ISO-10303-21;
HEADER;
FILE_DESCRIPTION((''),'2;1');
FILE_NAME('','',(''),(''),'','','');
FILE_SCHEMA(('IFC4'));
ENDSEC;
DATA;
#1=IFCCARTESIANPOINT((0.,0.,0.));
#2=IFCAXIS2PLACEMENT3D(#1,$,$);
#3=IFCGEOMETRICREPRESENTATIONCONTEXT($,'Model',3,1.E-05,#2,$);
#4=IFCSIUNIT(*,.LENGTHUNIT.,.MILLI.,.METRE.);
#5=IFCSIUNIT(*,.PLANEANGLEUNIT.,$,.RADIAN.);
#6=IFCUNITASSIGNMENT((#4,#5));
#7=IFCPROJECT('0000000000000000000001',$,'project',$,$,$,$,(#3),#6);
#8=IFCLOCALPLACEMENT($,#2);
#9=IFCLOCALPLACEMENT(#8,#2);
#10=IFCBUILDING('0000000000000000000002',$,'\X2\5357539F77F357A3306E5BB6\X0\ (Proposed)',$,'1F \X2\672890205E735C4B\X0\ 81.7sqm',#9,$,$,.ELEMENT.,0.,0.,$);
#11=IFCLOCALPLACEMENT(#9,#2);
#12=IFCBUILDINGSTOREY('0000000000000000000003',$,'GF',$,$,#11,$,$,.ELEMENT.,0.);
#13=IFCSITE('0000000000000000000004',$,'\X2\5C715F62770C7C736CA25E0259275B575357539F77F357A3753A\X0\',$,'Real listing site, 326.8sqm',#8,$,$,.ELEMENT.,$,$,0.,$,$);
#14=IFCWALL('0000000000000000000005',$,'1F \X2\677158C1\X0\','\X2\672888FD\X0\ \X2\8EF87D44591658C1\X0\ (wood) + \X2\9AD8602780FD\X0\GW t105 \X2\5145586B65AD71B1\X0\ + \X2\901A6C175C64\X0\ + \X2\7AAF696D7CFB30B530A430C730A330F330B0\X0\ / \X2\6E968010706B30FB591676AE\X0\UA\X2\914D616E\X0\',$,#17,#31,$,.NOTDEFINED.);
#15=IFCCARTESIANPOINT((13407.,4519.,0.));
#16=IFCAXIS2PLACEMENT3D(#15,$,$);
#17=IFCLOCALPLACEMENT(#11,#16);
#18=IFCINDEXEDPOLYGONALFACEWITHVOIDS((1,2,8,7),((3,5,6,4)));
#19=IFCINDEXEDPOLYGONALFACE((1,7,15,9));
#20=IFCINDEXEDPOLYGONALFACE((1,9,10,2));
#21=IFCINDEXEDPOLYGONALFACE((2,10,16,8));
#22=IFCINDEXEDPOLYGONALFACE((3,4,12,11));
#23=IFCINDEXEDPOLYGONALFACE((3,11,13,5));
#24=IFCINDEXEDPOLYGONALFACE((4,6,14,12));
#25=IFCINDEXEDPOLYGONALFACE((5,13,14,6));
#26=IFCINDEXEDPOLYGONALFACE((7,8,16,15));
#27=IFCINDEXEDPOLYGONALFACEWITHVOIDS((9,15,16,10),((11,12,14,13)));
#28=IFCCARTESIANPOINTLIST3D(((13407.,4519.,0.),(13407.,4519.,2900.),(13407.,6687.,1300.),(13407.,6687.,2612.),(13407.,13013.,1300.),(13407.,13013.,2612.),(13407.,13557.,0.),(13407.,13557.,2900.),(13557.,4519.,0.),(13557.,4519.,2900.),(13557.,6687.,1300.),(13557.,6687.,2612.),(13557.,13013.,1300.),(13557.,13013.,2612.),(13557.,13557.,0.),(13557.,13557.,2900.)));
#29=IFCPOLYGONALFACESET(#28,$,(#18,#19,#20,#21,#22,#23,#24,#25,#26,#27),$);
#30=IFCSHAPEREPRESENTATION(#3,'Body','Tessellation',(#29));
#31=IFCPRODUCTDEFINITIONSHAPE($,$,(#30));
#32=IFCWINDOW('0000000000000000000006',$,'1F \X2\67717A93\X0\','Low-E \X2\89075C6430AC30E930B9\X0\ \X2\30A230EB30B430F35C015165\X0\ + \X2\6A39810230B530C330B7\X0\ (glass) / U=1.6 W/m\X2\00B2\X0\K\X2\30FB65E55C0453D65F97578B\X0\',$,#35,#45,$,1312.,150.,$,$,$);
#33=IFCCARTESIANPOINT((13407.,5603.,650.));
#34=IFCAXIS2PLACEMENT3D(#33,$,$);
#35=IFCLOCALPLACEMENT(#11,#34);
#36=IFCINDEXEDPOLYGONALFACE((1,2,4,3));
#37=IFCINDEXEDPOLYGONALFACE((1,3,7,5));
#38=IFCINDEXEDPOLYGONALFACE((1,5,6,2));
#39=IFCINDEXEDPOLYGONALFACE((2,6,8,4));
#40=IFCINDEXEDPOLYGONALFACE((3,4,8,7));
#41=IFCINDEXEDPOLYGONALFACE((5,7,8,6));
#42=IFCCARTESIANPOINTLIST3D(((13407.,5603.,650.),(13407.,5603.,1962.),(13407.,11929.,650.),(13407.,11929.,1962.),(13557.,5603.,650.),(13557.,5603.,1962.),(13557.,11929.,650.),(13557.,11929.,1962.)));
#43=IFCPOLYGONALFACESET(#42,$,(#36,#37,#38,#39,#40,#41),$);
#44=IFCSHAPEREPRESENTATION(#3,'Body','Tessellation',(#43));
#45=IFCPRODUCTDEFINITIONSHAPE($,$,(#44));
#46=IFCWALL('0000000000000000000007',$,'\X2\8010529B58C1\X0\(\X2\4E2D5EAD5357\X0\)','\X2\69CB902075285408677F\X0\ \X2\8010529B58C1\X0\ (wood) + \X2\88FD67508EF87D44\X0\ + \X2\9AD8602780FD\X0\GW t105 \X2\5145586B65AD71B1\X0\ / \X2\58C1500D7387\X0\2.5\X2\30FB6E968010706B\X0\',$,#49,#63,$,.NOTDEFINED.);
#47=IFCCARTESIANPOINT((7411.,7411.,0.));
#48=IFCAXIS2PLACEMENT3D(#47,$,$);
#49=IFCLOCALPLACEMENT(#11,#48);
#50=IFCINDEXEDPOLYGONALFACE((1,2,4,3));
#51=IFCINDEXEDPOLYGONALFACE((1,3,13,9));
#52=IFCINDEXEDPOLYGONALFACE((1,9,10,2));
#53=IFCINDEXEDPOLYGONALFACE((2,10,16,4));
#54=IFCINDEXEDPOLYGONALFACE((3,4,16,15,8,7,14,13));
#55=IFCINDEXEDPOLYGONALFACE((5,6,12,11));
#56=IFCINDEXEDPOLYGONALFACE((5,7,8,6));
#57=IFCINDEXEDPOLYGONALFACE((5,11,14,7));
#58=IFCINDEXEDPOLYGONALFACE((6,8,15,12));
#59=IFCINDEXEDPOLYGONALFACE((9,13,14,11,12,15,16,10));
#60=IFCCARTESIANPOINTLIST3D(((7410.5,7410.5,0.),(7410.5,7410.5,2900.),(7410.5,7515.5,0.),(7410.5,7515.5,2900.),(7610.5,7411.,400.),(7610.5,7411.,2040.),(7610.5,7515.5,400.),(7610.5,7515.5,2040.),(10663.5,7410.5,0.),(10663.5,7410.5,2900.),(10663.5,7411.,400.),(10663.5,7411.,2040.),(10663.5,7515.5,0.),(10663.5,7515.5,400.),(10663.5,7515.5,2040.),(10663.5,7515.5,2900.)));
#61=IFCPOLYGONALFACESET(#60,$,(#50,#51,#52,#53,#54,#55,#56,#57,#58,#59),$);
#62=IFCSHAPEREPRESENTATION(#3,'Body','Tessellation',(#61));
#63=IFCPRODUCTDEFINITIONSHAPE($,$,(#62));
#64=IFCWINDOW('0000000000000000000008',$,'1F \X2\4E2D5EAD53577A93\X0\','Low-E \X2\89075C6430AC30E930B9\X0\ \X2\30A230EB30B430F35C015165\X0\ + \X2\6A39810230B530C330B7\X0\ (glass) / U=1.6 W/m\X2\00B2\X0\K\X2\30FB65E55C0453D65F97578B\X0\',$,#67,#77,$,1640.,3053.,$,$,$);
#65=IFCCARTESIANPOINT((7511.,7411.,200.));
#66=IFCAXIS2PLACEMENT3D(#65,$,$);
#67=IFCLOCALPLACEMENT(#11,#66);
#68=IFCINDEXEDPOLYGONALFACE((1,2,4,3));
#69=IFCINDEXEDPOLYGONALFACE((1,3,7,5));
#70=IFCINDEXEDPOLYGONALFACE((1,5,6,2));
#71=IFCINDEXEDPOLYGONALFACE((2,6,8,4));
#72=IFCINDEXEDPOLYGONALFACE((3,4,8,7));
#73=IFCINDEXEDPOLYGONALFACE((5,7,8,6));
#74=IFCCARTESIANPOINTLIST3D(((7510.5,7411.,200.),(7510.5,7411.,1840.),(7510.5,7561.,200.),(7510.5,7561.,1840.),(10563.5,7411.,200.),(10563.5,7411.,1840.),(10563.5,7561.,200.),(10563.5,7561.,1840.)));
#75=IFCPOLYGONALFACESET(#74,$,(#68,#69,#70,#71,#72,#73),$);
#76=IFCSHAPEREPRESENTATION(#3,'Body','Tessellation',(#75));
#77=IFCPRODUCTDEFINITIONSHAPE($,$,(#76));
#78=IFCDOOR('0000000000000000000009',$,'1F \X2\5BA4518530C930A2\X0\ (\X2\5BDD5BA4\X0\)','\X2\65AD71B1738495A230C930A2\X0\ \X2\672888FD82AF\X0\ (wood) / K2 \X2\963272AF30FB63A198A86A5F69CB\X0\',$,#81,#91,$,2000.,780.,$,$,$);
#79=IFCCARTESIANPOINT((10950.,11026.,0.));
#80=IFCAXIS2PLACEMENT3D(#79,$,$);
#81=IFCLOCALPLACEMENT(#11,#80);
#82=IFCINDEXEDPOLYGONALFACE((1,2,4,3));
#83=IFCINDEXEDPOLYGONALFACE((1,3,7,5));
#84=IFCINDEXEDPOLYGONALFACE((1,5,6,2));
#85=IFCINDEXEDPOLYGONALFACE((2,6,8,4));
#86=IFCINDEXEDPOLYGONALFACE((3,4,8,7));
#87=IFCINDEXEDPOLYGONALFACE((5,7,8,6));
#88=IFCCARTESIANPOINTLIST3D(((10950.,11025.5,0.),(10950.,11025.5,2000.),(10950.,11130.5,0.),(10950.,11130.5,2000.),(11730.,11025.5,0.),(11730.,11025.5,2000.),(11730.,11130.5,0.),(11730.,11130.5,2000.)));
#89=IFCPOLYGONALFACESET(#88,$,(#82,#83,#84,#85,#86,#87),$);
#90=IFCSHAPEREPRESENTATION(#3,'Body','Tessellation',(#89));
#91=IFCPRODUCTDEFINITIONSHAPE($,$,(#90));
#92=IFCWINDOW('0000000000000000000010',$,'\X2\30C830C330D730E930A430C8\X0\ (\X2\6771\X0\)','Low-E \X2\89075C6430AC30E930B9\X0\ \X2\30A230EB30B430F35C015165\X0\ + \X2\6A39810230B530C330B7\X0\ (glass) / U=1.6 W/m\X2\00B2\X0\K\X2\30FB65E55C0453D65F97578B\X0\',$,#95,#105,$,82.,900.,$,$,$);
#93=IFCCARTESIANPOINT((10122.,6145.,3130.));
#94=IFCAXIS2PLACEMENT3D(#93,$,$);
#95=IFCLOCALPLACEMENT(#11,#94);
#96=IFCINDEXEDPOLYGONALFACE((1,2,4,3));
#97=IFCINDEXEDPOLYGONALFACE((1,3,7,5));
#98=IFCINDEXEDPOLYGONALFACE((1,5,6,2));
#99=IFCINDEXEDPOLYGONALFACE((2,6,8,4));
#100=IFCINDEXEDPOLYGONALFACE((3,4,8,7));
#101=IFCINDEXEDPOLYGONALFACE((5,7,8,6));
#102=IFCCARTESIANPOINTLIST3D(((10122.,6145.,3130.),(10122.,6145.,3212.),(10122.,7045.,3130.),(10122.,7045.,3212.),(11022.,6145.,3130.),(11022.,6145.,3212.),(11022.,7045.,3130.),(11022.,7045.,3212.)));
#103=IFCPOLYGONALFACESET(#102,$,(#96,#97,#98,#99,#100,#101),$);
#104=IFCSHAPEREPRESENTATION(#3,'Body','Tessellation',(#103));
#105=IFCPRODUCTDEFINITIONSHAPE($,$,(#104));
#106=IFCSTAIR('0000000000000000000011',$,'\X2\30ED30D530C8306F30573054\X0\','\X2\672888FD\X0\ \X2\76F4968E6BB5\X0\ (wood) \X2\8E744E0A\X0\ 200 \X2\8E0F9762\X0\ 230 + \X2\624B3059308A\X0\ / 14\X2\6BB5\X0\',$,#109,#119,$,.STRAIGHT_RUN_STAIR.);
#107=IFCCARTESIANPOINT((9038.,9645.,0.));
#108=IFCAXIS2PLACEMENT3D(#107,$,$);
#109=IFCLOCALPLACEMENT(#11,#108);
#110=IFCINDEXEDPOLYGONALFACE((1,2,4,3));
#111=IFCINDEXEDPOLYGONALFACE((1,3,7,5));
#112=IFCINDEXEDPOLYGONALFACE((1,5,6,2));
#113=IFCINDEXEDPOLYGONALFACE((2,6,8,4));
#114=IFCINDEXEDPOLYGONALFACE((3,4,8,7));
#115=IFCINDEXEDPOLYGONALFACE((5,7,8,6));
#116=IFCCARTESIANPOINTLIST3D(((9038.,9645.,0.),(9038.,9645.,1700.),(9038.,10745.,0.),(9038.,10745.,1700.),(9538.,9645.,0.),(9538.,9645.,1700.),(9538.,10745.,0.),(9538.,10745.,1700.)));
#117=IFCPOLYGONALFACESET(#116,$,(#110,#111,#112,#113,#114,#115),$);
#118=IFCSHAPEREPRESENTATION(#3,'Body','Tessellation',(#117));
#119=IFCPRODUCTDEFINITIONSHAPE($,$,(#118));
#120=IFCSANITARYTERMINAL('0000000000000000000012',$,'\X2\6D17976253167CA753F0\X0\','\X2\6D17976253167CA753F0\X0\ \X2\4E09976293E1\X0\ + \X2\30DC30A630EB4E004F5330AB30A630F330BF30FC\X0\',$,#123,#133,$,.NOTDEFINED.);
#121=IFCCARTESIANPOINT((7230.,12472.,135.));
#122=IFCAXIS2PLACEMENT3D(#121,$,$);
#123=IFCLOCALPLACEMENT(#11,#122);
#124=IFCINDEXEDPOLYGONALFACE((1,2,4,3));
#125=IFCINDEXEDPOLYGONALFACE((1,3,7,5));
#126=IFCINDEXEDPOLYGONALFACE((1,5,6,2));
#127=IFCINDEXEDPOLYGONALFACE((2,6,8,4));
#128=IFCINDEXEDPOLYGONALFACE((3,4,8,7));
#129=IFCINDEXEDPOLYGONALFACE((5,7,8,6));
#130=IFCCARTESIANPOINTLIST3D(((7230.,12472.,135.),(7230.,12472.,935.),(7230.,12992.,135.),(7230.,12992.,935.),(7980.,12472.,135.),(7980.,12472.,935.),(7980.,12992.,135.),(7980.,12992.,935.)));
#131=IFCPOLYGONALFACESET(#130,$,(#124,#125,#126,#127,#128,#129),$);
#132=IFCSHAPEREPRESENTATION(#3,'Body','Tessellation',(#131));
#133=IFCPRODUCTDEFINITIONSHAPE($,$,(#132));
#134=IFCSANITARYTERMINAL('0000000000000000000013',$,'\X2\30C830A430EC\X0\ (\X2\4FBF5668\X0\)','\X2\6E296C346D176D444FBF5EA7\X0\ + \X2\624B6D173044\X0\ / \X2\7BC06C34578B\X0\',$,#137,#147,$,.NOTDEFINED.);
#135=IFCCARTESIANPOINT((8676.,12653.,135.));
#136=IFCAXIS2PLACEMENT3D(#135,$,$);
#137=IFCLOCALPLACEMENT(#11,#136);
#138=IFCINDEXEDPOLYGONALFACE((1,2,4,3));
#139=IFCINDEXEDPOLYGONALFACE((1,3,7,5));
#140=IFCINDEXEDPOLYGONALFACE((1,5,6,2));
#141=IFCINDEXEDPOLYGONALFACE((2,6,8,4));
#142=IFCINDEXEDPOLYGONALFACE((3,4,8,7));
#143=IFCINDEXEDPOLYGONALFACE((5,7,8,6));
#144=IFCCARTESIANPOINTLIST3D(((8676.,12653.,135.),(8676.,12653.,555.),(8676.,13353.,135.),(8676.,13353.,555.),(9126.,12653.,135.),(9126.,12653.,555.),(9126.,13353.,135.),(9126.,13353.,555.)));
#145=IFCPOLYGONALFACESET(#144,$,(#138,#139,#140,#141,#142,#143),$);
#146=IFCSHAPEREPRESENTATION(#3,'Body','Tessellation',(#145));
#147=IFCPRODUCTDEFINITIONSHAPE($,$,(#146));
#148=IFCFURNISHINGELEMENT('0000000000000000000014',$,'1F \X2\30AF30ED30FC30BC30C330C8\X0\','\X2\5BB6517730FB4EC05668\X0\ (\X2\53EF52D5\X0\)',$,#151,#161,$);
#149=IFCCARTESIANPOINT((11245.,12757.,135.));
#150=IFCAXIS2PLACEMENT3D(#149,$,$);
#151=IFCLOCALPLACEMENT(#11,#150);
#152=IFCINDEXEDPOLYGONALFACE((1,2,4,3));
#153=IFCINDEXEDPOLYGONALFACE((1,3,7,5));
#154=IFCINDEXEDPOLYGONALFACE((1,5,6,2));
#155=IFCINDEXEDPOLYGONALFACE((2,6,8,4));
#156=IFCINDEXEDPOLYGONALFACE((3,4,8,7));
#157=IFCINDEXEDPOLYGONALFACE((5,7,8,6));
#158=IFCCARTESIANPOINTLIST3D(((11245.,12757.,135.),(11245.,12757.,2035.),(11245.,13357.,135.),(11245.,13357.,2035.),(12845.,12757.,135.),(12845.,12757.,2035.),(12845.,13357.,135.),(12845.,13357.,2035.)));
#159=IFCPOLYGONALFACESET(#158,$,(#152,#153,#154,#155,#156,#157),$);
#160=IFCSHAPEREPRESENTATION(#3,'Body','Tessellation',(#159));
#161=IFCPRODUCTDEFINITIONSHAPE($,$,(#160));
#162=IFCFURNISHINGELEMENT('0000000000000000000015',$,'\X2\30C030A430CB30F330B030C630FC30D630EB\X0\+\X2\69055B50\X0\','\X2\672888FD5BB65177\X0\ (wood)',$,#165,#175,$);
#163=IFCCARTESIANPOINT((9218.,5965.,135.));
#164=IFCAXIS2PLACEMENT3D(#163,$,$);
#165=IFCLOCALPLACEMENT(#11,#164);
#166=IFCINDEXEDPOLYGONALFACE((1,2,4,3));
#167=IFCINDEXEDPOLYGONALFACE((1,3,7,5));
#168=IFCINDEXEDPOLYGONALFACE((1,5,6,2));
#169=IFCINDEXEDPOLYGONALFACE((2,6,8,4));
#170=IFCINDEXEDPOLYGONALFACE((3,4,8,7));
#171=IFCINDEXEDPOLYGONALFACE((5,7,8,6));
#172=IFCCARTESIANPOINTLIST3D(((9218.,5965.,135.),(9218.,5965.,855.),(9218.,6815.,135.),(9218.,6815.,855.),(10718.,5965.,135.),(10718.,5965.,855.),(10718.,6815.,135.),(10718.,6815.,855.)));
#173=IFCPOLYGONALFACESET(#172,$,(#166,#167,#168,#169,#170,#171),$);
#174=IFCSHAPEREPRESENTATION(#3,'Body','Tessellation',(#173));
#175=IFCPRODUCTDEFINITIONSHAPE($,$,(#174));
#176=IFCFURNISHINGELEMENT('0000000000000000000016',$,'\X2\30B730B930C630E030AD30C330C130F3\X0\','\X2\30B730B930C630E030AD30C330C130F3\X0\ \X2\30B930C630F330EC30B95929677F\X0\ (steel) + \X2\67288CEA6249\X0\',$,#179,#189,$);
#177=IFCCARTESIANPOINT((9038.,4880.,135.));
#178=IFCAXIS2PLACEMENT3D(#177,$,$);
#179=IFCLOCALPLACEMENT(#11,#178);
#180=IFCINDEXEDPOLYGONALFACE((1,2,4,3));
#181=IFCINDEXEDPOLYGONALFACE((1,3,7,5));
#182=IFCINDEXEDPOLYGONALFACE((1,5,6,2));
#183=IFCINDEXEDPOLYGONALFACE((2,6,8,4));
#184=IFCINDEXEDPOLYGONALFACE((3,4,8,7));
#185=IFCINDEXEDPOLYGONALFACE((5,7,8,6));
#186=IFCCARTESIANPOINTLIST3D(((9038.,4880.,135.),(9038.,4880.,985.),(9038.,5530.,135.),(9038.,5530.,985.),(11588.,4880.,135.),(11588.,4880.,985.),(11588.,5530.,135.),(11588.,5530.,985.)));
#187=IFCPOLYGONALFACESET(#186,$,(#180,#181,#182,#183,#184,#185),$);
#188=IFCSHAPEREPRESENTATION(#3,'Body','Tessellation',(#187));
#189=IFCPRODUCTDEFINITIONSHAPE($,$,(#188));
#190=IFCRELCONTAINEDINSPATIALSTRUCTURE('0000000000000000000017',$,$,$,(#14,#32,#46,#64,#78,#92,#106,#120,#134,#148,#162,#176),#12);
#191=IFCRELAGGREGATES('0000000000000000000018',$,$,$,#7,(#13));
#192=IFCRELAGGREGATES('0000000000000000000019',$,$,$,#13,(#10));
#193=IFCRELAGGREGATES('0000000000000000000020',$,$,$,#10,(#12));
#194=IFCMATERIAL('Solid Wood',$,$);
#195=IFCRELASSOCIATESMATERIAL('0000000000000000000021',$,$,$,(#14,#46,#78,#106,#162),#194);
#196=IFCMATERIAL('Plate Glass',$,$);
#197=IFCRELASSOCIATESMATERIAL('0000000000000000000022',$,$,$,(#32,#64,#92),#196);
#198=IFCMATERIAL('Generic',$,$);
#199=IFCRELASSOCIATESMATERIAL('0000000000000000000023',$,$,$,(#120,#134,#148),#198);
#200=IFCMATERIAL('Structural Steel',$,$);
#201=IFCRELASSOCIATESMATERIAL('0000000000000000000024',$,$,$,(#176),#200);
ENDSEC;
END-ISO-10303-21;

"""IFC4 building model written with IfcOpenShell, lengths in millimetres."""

from ifc_helpers import new_model, si_unit, frame, frame_2d, origin, place, context, project, spatial, rectangle, extrude, material, element, fill, save


model = new_model("IFC4")

# Units and contexts
model_context = context("Model", 3, precision=1e-05, world=origin())
ifc_project = project(units=[si_unit("LENGTHUNIT", "METRE", prefix="MILLI"), si_unit("PLANEANGLEUNIT", "RADIAN")], contexts=[model_context])

# Site, building, storey
site_placement = place(None, origin())
site = spatial("IfcSite", under=ifc_project, at=site_placement, Name="山形県米沢市大字南原石垣町", ObjectType="Real listing site, 326.8sqm", CompositionType="ELEMENT", RefElevation=0.0)
building_placement = place(site_placement, origin())
building = spatial("IfcBuilding", under=site, at=building_placement, Name="南原石垣の家 (Proposed)", ObjectType="1F 木造平屋 81.7sqm", CompositionType="ELEMENT", ElevationOfRefHeight=0.0, ElevationOfTerrain=0.0)
storey_placement = place(building_placement, origin())
storey = spatial("IfcBuildingStorey", under=building, at=storey_placement, Name="GF", CompositionType="ELEMENT", Elevation=0.0)

# Shared definitions
ifc_material_1 = material(Name="Solid Wood")

# Walls, openings, windows
wall_1_placement = place(storey_placement, frame((13407.0, 4519.0, 0.0)))
wall_1 = element("IfcWall", 1, at=wall_1_placement, inside=storey, material=ifc_material_1, Name="1F 東壁", Description="木製 軸組外壁 (wood) + 高性能GW t105 充填断熱 + 通気層 + 窯業系サイディング / 準耐火・外皮UA配慮", PredefinedType="NOTDEFINED", context=model_context, shape_type="SweptSolid", body=[
    extrude(rectangle(XDim=150.0, YDim=9038.0, at=frame_2d((75.0, 4519.0))), frame((13407.0, 4519.0, 0.0)), (0.0, 0.0, 1.0), 2900.0),
])
opening_1_placement = place(storey_placement, frame((13407.0, 5603.0, 650.0)))
opening_1 = element("IfcOpeningElement", 2, at=opening_1_placement, cuts=wall_1, PredefinedType="NOTDEFINED", context=model_context, shape_type="SweptSolid", body=[
    extrude(rectangle(XDim=150.0, YDim=6326.0, at=frame_2d((75.0, 3163.0))), frame((13407.0, 5603.0, 650.0)), (0.0, 0.0, 1.0), 1312.0),
])
ifc_material_2 = material(Name="Plate Glass")
window_1_placement = place(storey_placement, frame((13407.0, 5603.0, 650.0)))
window_1 = element("IfcWindow", 3, at=window_1_placement, inside=storey, material=ifc_material_2, Name="1F 東窓", Description="Low-E 複層ガラス アルゴン封入 + 樹脂サッシ (glass) / U=1.6 W/m²K・日射取得型", OverallHeight=1312.0, OverallWidth=150.0, context=model_context, shape_type="SweptSolid", body=[
    extrude(rectangle(XDim=150.0, YDim=6326.0, at=frame_2d((75.0, 3163.0))), frame((13407.0, 5603.0, 650.0)), (0.0, 0.0, 1.0), 1312.0),
])
fill(opening_1, window_1)
wall_2_placement = place(storey_placement, frame((7411.0, 7411.0, 0.0)))
wall_2 = element("IfcWall", 4, at=wall_2_placement, inside=storey, material=ifc_material_1, Name="耐力壁(中庭南)", Description="構造用合板 耐力壁 (wood) + 製材軸組 + 高性能GW t105 充填断熱 / 壁倍率2.5・準耐火", PredefinedType="NOTDEFINED", context=model_context, shape_type="SweptSolid", body=[
    extrude(rectangle(XDim=3253.0, YDim=105.0, at=frame_2d((1626.0, 52.0))), frame((7411.0, 7411.0, 0.0)), (0.0, 0.0, 1.0), 2900.0),
])
opening_2_placement = place(storey_placement, frame((7511.0, 7411.0, 200.0)))
opening_2 = element("IfcOpeningElement", 5, at=opening_2_placement, cuts=wall_2, PredefinedType="NOTDEFINED", context=model_context, shape_type="SweptSolid", body=[
    extrude(rectangle(XDim=3053.0, YDim=150.0, at=frame_2d((1526.0, 75.0))), frame((7511.0, 7411.0, 200.0)), (0.0, 0.0, 1.0), 1640.0),
])
window_2_placement = place(storey_placement, frame((7511.0, 7411.0, 200.0)))
window_2 = element("IfcWindow", 6, at=window_2_placement, inside=storey, material=ifc_material_2, Name="1F 中庭南窓", Description="Low-E 複層ガラス アルゴン封入 + 樹脂サッシ (glass) / U=1.6 W/m²K・日射取得型", OverallHeight=1640.0, OverallWidth=3053.0, context=model_context, shape_type="SweptSolid", body=[
    extrude(rectangle(XDim=3053.0, YDim=150.0, at=frame_2d((1526.0, 75.0))), frame((7511.0, 7411.0, 200.0)), (0.0, 0.0, 1.0), 1640.0),
])
fill(opening_2, window_2)

# Door
door_placement = place(storey_placement, frame((10950.0, 11026.0, 0.0)))
element("IfcDoor", 7, at=door_placement, inside=storey, material=ifc_material_1, Name="1F 室内ドア (寝室)", Description="断熱玄関ドア 木製芯 (wood) / K2 防犯・採風機構", OverallHeight=2000.0, OverallWidth=780.0, context=model_context, shape_type="SweptSolid", body=[
    extrude(rectangle(XDim=780.0, YDim=105.0, at=frame_2d((390.0, 52.0))), frame((10950.0, 11026.0, 0.0)), (0.0, 0.0, 1.0), 2000.0),
])

# Window
window_3_placement = place(storey_placement, frame((10122.0, 6145.0, 3130.0)))
element("IfcWindow", 8, at=window_3_placement, inside=storey, material=ifc_material_2, Name="トップライト (東)", Description="Low-E 複層ガラス アルゴン封入 + 樹脂サッシ (glass) / U=1.6 W/m²K・日射取得型", OverallHeight=82.0, OverallWidth=900.0, context=model_context, shape_type="SweptSolid", body=[
    extrude(rectangle(XDim=900.0, YDim=900.0, at=frame_2d((450.0, 450.0))), frame((10122.0, 6145.0, 3130.0)), (0.0, 0.0, 1.0), 82.0),
])

# Stair
stair_placement = place(storey_placement, frame((9038.0, 9645.0, 0.0)))
element("IfcStair", 9, at=stair_placement, inside=storey, material=ifc_material_1, Name="ロフトはしご", Description="木製 直階段 (wood) 蹴上 200 踏面 230 + 手すり / 14段", PredefinedType="STRAIGHT_RUN_STAIR", context=model_context, shape_type="SweptSolid", body=[
    extrude(rectangle(XDim=500.0, YDim=1100.0, at=frame_2d((250.0, 550.0))), frame((9038.0, 9645.0, 0.0)), (0.0, 0.0, 1.0), 1700.0),
])

# Shared definitions
ifc_material_3 = material(Name="Structural Steel")

# Shared definitions
ifc_material_4 = material(Name="Generic")

# Sanitary terminals
sanitary_terminal_1_placement = place(storey_placement, frame((7230.0, 12472.0, 135.0)))
element("IfcSanitaryTerminal", 10, at=sanitary_terminal_1_placement, inside=storey, material=ifc_material_4, Name="洗面化粧台", Description="洗面化粧台 三面鏡 + ボウル一体カウンター", PredefinedType="NOTDEFINED", context=model_context, shape_type="SweptSolid", body=[
    extrude(rectangle(XDim=750.0, YDim=520.0, at=frame_2d((375.0, 260.0))), frame((7230.0, 12472.0, 135.0)), (0.0, 0.0, 1.0), 800.0),
])
sanitary_terminal_2_placement = place(storey_placement, frame((8676.0, 12653.0, 135.0)))
element("IfcSanitaryTerminal", 11, at=sanitary_terminal_2_placement, inside=storey, material=ifc_material_4, Name="トイレ (便器)", Description="温水洗浄便座 + 手洗い / 節水型", PredefinedType="NOTDEFINED", context=model_context, shape_type="SweptSolid", body=[
    extrude(rectangle(XDim=450.0, YDim=700.0, at=frame_2d((225.0, 350.0))), frame((8676.0, 12653.0, 135.0)), (0.0, 0.0, 1.0), 420.0),
])

# Furnishing elements
furnishing_1_placement = place(storey_placement, frame((11245.0, 12757.0, 135.0)))
element("IfcFurnishingElement", 12, at=furnishing_1_placement, inside=storey, material=ifc_material_4, Name="1F クローゼット", Description="家具・什器 (可動)", context=model_context, shape_type="SweptSolid", body=[
    extrude(rectangle(XDim=1600.0, YDim=600.0, at=frame_2d((800.0, 300.0))), frame((11245.0, 12757.0, 135.0)), (0.0, 0.0, 1.0), 1900.0),
])
furnishing_2_placement = place(storey_placement, frame((9218.0, 5965.0, 135.0)))
element("IfcFurnishingElement", 13, at=furnishing_2_placement, inside=storey, material=ifc_material_1, Name="ダイニングテーブル+椅子", Description="木製家具 (wood)", context=model_context, shape_type="SweptSolid", body=[
    extrude(rectangle(XDim=1500.0, YDim=850.0, at=frame_2d((750.0, 425.0))), frame((9218.0, 5965.0, 135.0)), (0.0, 0.0, 1.0), 720.0),
])
furnishing_3_placement = place(storey_placement, frame((9038.0, 4880.0, 135.0)))
element("IfcFurnishingElement", 14, at=furnishing_3_placement, inside=storey, material=ifc_material_3, Name="システムキッチン", Description="システムキッチン ステンレス天板 (steel) + 木質扉", context=model_context, shape_type="SweptSolid", body=[
    extrude(rectangle(XDim=2550.0, YDim=650.0, at=frame_2d((1275.0, 325.0))), frame((9038.0, 4880.0, 135.0)), (0.0, 0.0, 1.0), 850.0),
])

save(model, "model.ifc")
